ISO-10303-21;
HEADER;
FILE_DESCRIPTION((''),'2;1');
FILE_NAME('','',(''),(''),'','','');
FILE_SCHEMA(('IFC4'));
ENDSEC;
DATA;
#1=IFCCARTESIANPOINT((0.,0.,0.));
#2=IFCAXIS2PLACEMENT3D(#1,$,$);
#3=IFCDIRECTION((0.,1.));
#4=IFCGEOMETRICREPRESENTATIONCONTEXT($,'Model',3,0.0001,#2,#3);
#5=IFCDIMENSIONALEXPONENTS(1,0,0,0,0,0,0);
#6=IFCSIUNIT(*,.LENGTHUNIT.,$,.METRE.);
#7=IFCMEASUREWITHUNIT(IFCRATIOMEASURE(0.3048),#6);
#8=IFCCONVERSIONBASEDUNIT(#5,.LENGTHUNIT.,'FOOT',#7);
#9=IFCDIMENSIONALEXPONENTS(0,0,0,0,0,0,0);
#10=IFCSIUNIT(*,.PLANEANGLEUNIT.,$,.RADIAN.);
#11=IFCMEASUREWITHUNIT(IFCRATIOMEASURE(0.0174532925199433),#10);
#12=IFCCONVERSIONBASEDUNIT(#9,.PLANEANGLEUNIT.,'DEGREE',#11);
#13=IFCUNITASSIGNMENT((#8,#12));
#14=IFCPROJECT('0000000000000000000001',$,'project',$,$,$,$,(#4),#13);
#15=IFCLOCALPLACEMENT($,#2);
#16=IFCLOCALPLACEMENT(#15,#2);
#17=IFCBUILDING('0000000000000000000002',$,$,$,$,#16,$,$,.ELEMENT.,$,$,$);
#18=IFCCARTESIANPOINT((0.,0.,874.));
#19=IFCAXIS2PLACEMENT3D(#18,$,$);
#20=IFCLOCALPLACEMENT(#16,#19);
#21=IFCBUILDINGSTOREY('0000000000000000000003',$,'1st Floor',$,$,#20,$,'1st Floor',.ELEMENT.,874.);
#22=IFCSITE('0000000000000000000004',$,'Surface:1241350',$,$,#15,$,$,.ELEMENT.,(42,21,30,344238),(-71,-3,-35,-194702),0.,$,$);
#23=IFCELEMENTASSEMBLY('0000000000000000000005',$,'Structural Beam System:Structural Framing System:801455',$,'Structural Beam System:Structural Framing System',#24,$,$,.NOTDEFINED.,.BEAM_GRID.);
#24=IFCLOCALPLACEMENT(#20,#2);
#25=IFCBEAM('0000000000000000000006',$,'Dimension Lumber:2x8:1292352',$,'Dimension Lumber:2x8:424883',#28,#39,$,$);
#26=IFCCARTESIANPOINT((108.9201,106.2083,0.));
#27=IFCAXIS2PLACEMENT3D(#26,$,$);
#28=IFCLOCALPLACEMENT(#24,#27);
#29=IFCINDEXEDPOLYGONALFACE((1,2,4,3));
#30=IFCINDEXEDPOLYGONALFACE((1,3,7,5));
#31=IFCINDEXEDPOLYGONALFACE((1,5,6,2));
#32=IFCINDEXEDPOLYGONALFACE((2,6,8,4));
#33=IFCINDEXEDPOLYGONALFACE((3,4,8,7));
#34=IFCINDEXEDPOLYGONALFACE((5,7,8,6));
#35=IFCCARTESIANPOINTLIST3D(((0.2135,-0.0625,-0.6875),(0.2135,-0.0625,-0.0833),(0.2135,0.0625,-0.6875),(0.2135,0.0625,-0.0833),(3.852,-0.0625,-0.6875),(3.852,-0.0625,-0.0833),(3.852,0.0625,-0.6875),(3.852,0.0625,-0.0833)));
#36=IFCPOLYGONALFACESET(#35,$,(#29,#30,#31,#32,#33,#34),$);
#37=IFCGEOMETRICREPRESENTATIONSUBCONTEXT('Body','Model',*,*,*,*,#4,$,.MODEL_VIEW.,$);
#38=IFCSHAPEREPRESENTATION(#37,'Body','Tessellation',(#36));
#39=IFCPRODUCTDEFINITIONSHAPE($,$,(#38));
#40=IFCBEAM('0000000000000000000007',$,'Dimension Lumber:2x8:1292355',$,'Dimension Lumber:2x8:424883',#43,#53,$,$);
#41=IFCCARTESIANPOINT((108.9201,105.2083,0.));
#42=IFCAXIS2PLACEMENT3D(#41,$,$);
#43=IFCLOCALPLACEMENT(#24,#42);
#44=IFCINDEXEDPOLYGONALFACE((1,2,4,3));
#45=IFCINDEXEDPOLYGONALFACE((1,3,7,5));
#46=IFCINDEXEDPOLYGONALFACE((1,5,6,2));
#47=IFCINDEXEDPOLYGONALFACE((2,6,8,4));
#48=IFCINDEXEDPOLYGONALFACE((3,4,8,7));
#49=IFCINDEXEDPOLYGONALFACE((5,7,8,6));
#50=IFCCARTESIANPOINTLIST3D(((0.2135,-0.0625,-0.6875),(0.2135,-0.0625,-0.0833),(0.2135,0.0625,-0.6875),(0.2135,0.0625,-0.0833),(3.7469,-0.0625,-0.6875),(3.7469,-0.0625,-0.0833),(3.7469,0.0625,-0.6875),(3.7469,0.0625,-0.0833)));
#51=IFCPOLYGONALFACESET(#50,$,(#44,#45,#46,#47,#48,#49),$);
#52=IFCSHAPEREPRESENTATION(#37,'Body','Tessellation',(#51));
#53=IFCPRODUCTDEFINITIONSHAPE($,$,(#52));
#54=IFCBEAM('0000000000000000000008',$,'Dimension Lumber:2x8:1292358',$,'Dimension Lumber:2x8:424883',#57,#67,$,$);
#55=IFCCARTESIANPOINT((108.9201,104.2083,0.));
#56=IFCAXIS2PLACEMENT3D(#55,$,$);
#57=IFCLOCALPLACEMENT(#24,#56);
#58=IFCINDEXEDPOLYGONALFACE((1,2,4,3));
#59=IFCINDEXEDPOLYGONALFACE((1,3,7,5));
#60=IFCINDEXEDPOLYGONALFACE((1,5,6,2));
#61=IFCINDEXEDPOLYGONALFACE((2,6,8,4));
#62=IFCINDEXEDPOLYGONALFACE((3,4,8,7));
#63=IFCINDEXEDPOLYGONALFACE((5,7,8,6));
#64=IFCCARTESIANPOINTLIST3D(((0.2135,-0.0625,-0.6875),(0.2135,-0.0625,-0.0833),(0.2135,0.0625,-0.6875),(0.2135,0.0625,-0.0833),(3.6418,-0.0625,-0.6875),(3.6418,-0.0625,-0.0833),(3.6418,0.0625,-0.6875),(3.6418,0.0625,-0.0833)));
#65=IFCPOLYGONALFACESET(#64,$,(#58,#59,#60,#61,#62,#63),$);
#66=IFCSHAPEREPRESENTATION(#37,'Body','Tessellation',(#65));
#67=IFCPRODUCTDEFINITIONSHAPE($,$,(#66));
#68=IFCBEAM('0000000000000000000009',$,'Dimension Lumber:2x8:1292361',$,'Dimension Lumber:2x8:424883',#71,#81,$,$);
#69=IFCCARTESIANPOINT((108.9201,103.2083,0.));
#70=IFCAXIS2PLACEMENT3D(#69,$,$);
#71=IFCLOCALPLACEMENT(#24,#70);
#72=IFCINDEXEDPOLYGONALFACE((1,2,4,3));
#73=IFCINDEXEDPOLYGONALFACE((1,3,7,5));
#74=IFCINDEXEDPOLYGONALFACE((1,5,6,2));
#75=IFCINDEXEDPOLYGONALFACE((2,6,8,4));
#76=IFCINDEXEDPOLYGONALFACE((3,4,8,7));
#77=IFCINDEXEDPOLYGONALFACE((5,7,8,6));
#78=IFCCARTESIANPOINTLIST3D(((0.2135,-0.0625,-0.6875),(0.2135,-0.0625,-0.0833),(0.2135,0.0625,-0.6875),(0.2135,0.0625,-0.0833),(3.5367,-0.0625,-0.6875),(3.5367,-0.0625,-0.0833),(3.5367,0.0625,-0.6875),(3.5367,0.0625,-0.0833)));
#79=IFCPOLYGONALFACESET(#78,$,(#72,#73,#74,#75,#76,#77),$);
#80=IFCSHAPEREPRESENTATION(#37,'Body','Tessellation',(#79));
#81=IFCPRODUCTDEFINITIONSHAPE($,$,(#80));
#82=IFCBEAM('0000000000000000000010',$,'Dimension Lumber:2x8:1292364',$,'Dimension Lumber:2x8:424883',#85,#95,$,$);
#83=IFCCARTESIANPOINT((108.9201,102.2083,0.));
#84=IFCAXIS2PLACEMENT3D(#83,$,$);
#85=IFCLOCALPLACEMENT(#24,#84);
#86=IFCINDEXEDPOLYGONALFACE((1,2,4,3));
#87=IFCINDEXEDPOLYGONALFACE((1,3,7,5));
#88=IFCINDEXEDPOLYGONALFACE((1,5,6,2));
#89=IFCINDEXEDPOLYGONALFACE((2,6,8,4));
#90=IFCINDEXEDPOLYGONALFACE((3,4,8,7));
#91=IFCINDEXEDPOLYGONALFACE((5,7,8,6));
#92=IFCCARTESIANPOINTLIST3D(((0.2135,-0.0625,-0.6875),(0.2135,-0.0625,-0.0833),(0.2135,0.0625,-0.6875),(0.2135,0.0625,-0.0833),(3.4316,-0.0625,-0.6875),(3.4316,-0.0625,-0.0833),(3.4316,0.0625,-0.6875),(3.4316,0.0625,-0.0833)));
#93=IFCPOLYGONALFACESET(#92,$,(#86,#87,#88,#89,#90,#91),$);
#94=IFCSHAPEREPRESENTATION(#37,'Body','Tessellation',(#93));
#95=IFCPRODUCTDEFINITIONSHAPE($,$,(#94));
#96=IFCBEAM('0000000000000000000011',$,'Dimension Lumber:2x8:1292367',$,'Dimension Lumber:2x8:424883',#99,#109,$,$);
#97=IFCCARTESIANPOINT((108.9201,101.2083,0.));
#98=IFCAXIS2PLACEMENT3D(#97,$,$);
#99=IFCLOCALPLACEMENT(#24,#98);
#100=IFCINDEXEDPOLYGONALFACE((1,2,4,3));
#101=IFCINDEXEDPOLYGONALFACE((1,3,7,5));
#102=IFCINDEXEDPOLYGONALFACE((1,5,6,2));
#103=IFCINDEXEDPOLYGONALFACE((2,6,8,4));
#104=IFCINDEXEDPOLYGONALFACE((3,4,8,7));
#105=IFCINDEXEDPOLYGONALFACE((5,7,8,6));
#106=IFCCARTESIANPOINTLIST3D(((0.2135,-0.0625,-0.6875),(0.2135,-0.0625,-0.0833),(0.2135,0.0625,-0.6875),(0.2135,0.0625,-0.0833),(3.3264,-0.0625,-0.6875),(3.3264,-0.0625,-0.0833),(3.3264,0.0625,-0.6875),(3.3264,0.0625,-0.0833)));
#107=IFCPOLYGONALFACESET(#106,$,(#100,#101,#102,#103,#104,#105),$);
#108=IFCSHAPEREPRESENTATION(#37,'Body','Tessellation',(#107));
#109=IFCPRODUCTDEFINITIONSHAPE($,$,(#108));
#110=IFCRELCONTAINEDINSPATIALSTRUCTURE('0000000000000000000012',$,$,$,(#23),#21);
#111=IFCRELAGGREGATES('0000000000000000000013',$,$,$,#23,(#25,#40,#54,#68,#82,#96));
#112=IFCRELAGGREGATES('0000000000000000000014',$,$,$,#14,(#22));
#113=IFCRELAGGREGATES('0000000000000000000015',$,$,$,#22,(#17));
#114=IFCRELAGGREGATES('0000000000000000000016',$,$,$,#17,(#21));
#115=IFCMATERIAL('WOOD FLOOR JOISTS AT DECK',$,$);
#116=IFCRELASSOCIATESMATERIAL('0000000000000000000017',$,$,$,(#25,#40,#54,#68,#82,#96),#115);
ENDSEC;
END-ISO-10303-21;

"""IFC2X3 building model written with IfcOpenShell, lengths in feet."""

from ifc_helpers import new_model, entity, si_unit, converted_unit, direction, frame, origin, origin_2d_with_axis, place, context, subcontext, project, spatial, rectangle, extrude, material, element, aggregate, save


model = new_model("IFC2X3")

# Units and contexts
model_context = context("Model", 3, precision=0.0001, world=origin(), true_north=direction((0.0, 1.0)))
body_context = subcontext(model_context, "Body", "Model", "MODEL_VIEW")
ifc_project = project(units=[converted_unit("LENGTHUNIT", "FOOT", entity("IfcRatioMeasure", 0.3048), si_unit("LENGTHUNIT", "METRE"), dimensions=[1, 0, 0, 0, 0, 0, 0]), converted_unit("PLANEANGLEUNIT", "DEGREE", entity("IfcRatioMeasure", 0.0174532925199433), si_unit("PLANEANGLEUNIT", "RADIAN"), dimensions=[0, 0, 0, 0, 0, 0, 0])], contexts=[model_context])

# Site, building, storey
site_placement = place(None, origin())
site = spatial("IfcSite", under=ifc_project, at=site_placement, Name="Surface:1241350", CompositionType="ELEMENT", RefLatitude=(42, 21, 30, 344238), RefLongitude=(-71, -3, -35, -194702), RefElevation=0.0)
building_placement = place(site_placement, origin())
building = spatial("IfcBuilding", under=site, at=building_placement, CompositionType="ELEMENT")
storey_placement = place(building_placement, frame((0.0, 0.0, 874.0)))
storey = spatial("IfcBuildingStorey", under=building, at=storey_placement, Name="1st Floor", LongName="1st Floor", CompositionType="ELEMENT", Elevation=874.0)

# Element assembly, beams
assembly_placement = place(storey_placement, origin())
assembly = element("IfcElementAssembly", 1, at=assembly_placement, inside=storey, Name="Structural Beam System:Structural Framing System:801455", ObjectType="Structural Beam System:Structural Framing System", AssemblyPlace="NOTDEFINED", PredefinedType="BEAM_GRID")
ifc_material_1 = material(Name="WOOD FLOOR JOISTS AT DECK")
beam_1_placement = place(assembly_placement, frame((108.9201, 106.2083, 0.0)))
beam_1 = element("IfcBeam", 2, at=beam_1_placement, material=ifc_material_1, Name="Dimension Lumber:2x8:1292352", ObjectType="Dimension Lumber:2x8:424883", context=body_context, shape_type="SweptSolid", body=[
    extrude(rectangle(XDim=0.6042, YDim=0.125, at=origin_2d_with_axis()), frame((0.2135, 0.0, -0.3854), z_axis=(1.0, 0.0, 0.0), x_axis=(0.0, 0.0, -1.0)), (0.0, 0.0, 1.0), 3.6384),
])
beam_2_placement = place(assembly_placement, frame((108.9201, 105.2083, 0.0)))
beam_2 = element("IfcBeam", 3, at=beam_2_placement, material=ifc_material_1, Name="Dimension Lumber:2x8:1292355", ObjectType="Dimension Lumber:2x8:424883", context=body_context, shape_type="SweptSolid", body=[
    extrude(rectangle(XDim=0.6042, YDim=0.125, at=origin_2d_with_axis()), frame((0.2135, 0.0, -0.3854), z_axis=(1.0, 0.0, 0.0), x_axis=(0.0, 0.0, -1.0)), (0.0, 0.0, 1.0), 3.5333),
])
beam_3_placement = place(assembly_placement, frame((108.9201, 104.2083, 0.0)))
beam_3 = element("IfcBeam", 4, at=beam_3_placement, material=ifc_material_1, Name="Dimension Lumber:2x8:1292358", ObjectType="Dimension Lumber:2x8:424883", context=body_context, shape_type="SweptSolid", body=[
    extrude(rectangle(XDim=0.6042, YDim=0.125, at=origin_2d_with_axis()), frame((0.2135, 0.0, -0.3854), z_axis=(1.0, 0.0, 0.0), x_axis=(0.0, 0.0, -1.0)), (0.0, 0.0, 1.0), 3.4282),
])
beam_4_placement = place(assembly_placement, frame((108.9201, 103.2083, 0.0)))
beam_4 = element("IfcBeam", 5, at=beam_4_placement, material=ifc_material_1, Name="Dimension Lumber:2x8:1292361", ObjectType="Dimension Lumber:2x8:424883", context=body_context, shape_type="SweptSolid", body=[
    extrude(rectangle(XDim=0.6042, YDim=0.125, at=origin_2d_with_axis()), frame((0.2135, 0.0, -0.3854), z_axis=(1.0, 0.0, 0.0), x_axis=(0.0, 0.0, -1.0)), (0.0, 0.0, 1.0), 3.3231),
])
beam_5_placement = place(assembly_placement, frame((108.9201, 102.2083, 0.0)))
beam_5 = element("IfcBeam", 6, at=beam_5_placement, material=ifc_material_1, Name="Dimension Lumber:2x8:1292364", ObjectType="Dimension Lumber:2x8:424883", context=body_context, shape_type="SweptSolid", body=[
    extrude(rectangle(XDim=0.6042, YDim=0.125, at=origin_2d_with_axis()), frame((0.2135, 0.0, -0.3854), z_axis=(1.0, 0.0, 0.0), x_axis=(0.0, 0.0, -1.0)), (0.0, 0.0, 1.0), 3.218),
])
beam_6_placement = place(assembly_placement, frame((108.9201, 101.2083, 0.0)))
beam_6 = element("IfcBeam", 7, at=beam_6_placement, material=ifc_material_1, Name="Dimension Lumber:2x8:1292367", ObjectType="Dimension Lumber:2x8:424883", context=body_context, shape_type="SweptSolid", body=[
    extrude(rectangle(XDim=0.6042, YDim=0.125, at=origin_2d_with_axis()), frame((0.2135, 0.0, -0.3854), z_axis=(1.0, 0.0, 0.0), x_axis=(0.0, 0.0, -1.0)), (0.0, 0.0, 1.0), 3.1129),
])
aggregate(assembly, [beam_1, beam_2, beam_3, beam_4, beam_5, beam_6])

save(model, "model.ifc")
